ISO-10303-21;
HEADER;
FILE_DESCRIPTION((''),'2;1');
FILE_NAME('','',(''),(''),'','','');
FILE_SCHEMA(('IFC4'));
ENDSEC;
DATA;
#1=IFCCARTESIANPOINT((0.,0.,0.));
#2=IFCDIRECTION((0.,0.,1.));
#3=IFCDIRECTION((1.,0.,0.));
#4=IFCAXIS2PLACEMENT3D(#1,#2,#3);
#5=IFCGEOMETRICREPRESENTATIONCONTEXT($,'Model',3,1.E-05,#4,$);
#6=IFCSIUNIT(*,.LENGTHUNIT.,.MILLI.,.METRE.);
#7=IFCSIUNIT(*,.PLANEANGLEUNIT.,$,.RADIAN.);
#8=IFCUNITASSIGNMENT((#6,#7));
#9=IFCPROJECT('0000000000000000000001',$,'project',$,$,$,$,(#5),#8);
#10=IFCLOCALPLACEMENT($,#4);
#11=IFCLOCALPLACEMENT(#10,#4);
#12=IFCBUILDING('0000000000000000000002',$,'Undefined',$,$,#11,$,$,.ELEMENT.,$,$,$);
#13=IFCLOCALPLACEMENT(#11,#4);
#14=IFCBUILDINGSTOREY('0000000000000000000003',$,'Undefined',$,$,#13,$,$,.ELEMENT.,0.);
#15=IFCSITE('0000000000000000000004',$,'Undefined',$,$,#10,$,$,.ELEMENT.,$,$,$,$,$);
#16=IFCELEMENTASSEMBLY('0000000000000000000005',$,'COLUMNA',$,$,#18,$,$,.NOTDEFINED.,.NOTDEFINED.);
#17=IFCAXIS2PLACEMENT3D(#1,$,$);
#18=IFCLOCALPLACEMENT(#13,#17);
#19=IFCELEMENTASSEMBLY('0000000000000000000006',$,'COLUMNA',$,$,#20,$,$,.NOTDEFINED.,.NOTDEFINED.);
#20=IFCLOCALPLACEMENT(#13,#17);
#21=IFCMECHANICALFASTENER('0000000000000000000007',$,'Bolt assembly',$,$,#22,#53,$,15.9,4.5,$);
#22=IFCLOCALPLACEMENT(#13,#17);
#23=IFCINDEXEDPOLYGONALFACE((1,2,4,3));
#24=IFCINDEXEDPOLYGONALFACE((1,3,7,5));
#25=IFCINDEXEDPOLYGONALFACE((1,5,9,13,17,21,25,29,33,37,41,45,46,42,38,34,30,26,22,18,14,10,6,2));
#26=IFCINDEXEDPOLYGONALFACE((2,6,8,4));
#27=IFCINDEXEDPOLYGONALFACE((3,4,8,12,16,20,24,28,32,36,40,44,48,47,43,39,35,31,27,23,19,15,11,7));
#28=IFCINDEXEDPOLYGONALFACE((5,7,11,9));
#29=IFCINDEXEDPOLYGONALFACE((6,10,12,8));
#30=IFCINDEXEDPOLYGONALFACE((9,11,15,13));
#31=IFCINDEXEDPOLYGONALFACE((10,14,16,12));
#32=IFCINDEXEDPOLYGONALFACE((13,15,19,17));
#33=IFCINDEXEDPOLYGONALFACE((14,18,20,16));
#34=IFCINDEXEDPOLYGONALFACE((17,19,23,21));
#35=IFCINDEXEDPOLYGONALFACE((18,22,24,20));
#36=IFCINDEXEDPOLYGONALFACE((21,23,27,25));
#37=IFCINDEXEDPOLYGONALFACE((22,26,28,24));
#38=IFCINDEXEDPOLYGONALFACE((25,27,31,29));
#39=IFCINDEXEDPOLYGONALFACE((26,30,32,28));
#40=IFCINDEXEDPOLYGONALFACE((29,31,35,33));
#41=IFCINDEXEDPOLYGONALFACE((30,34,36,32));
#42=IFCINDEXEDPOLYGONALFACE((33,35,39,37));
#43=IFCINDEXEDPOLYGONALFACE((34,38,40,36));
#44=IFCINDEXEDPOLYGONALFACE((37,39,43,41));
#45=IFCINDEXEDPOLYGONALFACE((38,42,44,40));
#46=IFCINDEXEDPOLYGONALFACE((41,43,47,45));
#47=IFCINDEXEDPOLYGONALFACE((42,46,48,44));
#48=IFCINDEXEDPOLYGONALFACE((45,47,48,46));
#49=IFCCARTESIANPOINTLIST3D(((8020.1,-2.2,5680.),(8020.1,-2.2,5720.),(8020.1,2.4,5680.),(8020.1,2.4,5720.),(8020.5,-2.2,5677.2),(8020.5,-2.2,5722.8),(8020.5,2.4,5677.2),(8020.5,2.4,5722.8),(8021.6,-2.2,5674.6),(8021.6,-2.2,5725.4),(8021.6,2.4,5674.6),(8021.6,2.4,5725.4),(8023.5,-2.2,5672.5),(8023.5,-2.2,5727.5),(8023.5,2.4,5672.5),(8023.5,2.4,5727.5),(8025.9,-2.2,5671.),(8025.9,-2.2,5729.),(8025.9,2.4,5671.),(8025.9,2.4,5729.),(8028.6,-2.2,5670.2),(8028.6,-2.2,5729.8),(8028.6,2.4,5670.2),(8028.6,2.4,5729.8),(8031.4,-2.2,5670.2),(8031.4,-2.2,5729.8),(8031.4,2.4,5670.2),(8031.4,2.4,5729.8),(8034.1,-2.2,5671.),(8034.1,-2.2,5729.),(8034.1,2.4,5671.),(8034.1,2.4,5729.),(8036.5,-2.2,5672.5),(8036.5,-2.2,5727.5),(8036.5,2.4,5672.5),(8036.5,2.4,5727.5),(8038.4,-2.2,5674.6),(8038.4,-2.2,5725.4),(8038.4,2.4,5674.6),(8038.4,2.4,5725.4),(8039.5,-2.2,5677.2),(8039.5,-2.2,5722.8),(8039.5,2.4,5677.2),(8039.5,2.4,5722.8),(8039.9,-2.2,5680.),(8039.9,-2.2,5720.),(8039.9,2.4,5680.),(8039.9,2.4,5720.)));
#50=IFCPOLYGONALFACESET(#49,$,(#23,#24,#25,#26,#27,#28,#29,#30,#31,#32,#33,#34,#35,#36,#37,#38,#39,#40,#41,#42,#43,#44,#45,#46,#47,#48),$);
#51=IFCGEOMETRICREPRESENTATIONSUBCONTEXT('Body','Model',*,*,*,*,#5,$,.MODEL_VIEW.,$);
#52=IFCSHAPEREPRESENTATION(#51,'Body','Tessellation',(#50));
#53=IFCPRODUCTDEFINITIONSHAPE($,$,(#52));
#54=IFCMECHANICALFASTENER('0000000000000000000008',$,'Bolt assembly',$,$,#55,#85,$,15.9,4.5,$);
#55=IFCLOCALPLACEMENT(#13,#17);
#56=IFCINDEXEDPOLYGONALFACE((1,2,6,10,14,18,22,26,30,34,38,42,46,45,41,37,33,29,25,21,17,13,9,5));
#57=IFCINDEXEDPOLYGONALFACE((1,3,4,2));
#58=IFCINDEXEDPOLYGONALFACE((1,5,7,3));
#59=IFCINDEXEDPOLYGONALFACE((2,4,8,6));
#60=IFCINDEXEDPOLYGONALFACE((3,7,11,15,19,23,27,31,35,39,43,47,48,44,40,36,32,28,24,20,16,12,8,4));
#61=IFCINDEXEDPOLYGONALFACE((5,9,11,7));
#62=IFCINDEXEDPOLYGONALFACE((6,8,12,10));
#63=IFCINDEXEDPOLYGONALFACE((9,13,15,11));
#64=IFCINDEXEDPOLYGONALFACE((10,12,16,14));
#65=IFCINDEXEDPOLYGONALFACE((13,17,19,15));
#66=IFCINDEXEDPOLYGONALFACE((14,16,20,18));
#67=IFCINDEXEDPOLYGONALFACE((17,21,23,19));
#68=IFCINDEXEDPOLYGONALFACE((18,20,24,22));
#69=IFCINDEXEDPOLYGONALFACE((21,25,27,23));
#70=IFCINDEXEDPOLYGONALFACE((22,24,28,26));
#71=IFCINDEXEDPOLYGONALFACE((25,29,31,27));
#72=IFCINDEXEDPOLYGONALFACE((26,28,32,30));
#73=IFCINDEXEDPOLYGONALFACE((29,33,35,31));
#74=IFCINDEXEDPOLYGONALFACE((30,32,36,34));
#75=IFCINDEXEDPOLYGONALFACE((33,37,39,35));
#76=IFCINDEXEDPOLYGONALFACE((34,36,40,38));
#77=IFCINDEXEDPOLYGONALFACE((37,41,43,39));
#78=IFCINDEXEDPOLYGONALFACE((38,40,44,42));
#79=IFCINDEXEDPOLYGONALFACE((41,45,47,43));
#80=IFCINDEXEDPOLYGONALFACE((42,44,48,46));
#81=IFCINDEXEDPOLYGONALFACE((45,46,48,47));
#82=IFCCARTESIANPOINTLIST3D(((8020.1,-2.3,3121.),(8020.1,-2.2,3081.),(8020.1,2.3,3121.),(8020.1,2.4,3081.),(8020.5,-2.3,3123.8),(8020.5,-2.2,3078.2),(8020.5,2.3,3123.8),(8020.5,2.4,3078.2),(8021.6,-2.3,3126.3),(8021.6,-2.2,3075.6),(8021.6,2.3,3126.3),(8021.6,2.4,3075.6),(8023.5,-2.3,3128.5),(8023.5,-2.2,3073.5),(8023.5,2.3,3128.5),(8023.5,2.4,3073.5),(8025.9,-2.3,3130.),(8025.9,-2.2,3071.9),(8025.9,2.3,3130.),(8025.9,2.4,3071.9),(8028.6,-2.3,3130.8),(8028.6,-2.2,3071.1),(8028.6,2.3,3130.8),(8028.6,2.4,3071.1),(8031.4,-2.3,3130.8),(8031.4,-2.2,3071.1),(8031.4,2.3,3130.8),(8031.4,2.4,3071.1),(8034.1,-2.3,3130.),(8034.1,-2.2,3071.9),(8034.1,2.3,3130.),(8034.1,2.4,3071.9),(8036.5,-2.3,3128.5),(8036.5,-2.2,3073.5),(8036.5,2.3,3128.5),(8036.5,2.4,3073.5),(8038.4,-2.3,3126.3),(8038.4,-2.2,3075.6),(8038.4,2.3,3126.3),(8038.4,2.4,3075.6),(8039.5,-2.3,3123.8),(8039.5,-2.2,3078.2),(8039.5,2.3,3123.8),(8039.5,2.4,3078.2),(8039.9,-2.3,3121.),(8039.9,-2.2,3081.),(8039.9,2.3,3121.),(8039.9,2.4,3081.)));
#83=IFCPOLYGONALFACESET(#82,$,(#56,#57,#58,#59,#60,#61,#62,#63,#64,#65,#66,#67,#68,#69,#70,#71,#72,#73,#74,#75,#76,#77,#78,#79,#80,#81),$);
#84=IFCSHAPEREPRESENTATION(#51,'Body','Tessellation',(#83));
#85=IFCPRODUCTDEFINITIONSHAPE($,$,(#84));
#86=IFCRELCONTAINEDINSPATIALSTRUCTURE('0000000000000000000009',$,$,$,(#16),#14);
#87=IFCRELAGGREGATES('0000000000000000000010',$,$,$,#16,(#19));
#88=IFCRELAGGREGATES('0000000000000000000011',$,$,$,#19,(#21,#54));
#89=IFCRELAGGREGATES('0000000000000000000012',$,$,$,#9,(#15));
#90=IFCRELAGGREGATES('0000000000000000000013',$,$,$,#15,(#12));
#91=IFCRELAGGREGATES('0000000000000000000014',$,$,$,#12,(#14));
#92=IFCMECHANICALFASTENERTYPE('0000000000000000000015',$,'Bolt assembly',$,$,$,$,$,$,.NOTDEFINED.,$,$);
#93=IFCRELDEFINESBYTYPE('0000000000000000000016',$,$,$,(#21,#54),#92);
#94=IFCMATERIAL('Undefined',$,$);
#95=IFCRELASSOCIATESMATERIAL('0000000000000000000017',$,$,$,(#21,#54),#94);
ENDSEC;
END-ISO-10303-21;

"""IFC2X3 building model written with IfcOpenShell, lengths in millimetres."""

from ifc_helpers import new_model, si_unit, frame, frame_2d, origin_with_axes, place, context, subcontext, project, spatial, polyline, circle_curve, parameter, trimmed, segment, composite_curve, outline, extrude, source, transform, mapped, material, type_object, element, aggregate, save


model = new_model("IFC2X3")

# Units and contexts
model_context = context("Model", 3, precision=1e-05, world=origin_with_axes())
body_context = subcontext(model_context, "Body", "Model", "MODEL_VIEW")
ifc_project = project(units=[si_unit("LENGTHUNIT", "METRE", prefix="MILLI"), si_unit("PLANEANGLEUNIT", "RADIAN")], contexts=[model_context])

# Site, building, storey
site_placement = place(None, origin_with_axes())
site = spatial("IfcSite", under=ifc_project, at=site_placement, Name="Undefined", CompositionType="ELEMENT")
building_placement = place(site_placement, origin_with_axes())
building = spatial("IfcBuilding", under=site, at=building_placement, Name="Undefined", CompositionType="ELEMENT")
storey_placement = place(building_placement, origin_with_axes())
storey = spatial("IfcBuildingStorey", under=building, at=storey_placement, Name="Undefined", CompositionType="ELEMENT", Elevation=0.0)

# Element assembly
assembly_1_placement = place(storey_placement, origin_with_axes())
assembly_1 = element("IfcElementAssembly", 1, at=assembly_1_placement, inside=storey, Name="COLUMNA", AssemblyPlace="NOTDEFINED", PredefinedType="NOTDEFINED")

# Element assembly
assembly_2_placement = place(assembly_1_placement, origin_with_axes())
assembly_2 = element("IfcElementAssembly", 2, at=assembly_2_placement, Name="COLUMNA", AssemblyPlace="NOTDEFINED", PredefinedType="NOTDEFINED")

aggregate(assembly_1, [assembly_2])

# Mechanical fasteners
ifc_material_1 = material(Name="Undefined")
mechanical_fastener_type = type_object("IfcMechanicalFastenerType", Name="Bolt assembly")
shared_shape_1 = source(origin_with_axes(), body_context, "Body", "SweptSolid", [
    extrude(outline(composite_curve([segment(polyline([(-20.0, 9.9), (20.0, 9.9)]), True, "CONTINUOUS"), segment(trimmed(circle_curve(frame_2d((20.0, 0.0), x_axis=(0.0, 1.0)), 9.9), [parameter(0.0)], [parameter(3.141593)], False, "PARAMETER"), True, "CONTINUOUS"), segment(polyline([(20.0, -9.9), (-20.0, -9.9)]), True, "CONTINUOUS"), segment(trimmed(circle_curve(frame_2d((-20.0, 0.0), x_axis=(0.0, -1.0)), 9.9), [parameter(0.0)], [parameter(3.141593)], False, "PARAMETER"), True, "DISCONTINUOUS")], self_intersect=False)), frame((0.0, -2.2, 0.0), z_axis=(0.0, 1.0, 0.0), x_axis=(1.0, 0.0, 0.0)), (0.0, 0.0, 1.0), 4.6),
])
mechanical_fastener_1_placement = place(assembly_2_placement, frame((8030.0, 0.0, 5700.0), z_axis=(1.0, 0.0, -0.000002), x_axis=(-0.000002, 0.0, -1.0)))
mechanical_fastener_1 = element("IfcMechanicalFastener", 3, at=mechanical_fastener_1_placement, type_object=mechanical_fastener_type, material=ifc_material_1, Name="Bolt assembly", NominalDiameter=15.9, NominalLength=4.5, context=body_context, shape_type="MappedRepresentation", body=[
    mapped(shared_shape_1, transform((0.0, 0.0, 0.0))),
])
shared_shape_2 = source(origin_with_axes(), body_context, "Body", "SweptSolid", [
    extrude(outline(composite_curve([segment(polyline([(-20.0, 9.9), (20.0, 9.9)]), True, "CONTINUOUS"), segment(trimmed(circle_curve(frame_2d((20.0, 0.0), x_axis=(0.0, 1.0)), 9.9), [parameter(0.0)], [parameter(3.141593)], False, "PARAMETER"), True, "CONTINUOUS"), segment(polyline([(20.0, -9.9), (-20.0, -9.9)]), True, "CONTINUOUS"), segment(trimmed(circle_curve(frame_2d((-20.0, 0.0), x_axis=(0.0, -1.0)), 9.9), [parameter(0.0)], [parameter(3.141593)], False, "PARAMETER"), True, "DISCONTINUOUS")], self_intersect=False)), frame((0.0, -2.2, 0.0), z_axis=(0.0, 1.0, 0.0), x_axis=(1.0, 0.0, 0.0)), (0.0, 0.0, 1.0), 4.6),
])
mechanical_fastener_2_placement = place(assembly_2_placement, frame((8030.0, 0.0, 3101.0), z_axis=(-1.0, 0.0, -0.000002), x_axis=(-0.000002, 0.0, 1.0)))
mechanical_fastener_2 = element("IfcMechanicalFastener", 4, at=mechanical_fastener_2_placement, type_object=mechanical_fastener_type, material=ifc_material_1, Name="Bolt assembly", NominalDiameter=15.9, NominalLength=4.5, context=body_context, shape_type="MappedRepresentation", body=[
    mapped(shared_shape_2, transform((0.0, 0.0, 0.0))),
])
aggregate(assembly_2, [mechanical_fastener_1, mechanical_fastener_2])

save(model, "model.ifc")
